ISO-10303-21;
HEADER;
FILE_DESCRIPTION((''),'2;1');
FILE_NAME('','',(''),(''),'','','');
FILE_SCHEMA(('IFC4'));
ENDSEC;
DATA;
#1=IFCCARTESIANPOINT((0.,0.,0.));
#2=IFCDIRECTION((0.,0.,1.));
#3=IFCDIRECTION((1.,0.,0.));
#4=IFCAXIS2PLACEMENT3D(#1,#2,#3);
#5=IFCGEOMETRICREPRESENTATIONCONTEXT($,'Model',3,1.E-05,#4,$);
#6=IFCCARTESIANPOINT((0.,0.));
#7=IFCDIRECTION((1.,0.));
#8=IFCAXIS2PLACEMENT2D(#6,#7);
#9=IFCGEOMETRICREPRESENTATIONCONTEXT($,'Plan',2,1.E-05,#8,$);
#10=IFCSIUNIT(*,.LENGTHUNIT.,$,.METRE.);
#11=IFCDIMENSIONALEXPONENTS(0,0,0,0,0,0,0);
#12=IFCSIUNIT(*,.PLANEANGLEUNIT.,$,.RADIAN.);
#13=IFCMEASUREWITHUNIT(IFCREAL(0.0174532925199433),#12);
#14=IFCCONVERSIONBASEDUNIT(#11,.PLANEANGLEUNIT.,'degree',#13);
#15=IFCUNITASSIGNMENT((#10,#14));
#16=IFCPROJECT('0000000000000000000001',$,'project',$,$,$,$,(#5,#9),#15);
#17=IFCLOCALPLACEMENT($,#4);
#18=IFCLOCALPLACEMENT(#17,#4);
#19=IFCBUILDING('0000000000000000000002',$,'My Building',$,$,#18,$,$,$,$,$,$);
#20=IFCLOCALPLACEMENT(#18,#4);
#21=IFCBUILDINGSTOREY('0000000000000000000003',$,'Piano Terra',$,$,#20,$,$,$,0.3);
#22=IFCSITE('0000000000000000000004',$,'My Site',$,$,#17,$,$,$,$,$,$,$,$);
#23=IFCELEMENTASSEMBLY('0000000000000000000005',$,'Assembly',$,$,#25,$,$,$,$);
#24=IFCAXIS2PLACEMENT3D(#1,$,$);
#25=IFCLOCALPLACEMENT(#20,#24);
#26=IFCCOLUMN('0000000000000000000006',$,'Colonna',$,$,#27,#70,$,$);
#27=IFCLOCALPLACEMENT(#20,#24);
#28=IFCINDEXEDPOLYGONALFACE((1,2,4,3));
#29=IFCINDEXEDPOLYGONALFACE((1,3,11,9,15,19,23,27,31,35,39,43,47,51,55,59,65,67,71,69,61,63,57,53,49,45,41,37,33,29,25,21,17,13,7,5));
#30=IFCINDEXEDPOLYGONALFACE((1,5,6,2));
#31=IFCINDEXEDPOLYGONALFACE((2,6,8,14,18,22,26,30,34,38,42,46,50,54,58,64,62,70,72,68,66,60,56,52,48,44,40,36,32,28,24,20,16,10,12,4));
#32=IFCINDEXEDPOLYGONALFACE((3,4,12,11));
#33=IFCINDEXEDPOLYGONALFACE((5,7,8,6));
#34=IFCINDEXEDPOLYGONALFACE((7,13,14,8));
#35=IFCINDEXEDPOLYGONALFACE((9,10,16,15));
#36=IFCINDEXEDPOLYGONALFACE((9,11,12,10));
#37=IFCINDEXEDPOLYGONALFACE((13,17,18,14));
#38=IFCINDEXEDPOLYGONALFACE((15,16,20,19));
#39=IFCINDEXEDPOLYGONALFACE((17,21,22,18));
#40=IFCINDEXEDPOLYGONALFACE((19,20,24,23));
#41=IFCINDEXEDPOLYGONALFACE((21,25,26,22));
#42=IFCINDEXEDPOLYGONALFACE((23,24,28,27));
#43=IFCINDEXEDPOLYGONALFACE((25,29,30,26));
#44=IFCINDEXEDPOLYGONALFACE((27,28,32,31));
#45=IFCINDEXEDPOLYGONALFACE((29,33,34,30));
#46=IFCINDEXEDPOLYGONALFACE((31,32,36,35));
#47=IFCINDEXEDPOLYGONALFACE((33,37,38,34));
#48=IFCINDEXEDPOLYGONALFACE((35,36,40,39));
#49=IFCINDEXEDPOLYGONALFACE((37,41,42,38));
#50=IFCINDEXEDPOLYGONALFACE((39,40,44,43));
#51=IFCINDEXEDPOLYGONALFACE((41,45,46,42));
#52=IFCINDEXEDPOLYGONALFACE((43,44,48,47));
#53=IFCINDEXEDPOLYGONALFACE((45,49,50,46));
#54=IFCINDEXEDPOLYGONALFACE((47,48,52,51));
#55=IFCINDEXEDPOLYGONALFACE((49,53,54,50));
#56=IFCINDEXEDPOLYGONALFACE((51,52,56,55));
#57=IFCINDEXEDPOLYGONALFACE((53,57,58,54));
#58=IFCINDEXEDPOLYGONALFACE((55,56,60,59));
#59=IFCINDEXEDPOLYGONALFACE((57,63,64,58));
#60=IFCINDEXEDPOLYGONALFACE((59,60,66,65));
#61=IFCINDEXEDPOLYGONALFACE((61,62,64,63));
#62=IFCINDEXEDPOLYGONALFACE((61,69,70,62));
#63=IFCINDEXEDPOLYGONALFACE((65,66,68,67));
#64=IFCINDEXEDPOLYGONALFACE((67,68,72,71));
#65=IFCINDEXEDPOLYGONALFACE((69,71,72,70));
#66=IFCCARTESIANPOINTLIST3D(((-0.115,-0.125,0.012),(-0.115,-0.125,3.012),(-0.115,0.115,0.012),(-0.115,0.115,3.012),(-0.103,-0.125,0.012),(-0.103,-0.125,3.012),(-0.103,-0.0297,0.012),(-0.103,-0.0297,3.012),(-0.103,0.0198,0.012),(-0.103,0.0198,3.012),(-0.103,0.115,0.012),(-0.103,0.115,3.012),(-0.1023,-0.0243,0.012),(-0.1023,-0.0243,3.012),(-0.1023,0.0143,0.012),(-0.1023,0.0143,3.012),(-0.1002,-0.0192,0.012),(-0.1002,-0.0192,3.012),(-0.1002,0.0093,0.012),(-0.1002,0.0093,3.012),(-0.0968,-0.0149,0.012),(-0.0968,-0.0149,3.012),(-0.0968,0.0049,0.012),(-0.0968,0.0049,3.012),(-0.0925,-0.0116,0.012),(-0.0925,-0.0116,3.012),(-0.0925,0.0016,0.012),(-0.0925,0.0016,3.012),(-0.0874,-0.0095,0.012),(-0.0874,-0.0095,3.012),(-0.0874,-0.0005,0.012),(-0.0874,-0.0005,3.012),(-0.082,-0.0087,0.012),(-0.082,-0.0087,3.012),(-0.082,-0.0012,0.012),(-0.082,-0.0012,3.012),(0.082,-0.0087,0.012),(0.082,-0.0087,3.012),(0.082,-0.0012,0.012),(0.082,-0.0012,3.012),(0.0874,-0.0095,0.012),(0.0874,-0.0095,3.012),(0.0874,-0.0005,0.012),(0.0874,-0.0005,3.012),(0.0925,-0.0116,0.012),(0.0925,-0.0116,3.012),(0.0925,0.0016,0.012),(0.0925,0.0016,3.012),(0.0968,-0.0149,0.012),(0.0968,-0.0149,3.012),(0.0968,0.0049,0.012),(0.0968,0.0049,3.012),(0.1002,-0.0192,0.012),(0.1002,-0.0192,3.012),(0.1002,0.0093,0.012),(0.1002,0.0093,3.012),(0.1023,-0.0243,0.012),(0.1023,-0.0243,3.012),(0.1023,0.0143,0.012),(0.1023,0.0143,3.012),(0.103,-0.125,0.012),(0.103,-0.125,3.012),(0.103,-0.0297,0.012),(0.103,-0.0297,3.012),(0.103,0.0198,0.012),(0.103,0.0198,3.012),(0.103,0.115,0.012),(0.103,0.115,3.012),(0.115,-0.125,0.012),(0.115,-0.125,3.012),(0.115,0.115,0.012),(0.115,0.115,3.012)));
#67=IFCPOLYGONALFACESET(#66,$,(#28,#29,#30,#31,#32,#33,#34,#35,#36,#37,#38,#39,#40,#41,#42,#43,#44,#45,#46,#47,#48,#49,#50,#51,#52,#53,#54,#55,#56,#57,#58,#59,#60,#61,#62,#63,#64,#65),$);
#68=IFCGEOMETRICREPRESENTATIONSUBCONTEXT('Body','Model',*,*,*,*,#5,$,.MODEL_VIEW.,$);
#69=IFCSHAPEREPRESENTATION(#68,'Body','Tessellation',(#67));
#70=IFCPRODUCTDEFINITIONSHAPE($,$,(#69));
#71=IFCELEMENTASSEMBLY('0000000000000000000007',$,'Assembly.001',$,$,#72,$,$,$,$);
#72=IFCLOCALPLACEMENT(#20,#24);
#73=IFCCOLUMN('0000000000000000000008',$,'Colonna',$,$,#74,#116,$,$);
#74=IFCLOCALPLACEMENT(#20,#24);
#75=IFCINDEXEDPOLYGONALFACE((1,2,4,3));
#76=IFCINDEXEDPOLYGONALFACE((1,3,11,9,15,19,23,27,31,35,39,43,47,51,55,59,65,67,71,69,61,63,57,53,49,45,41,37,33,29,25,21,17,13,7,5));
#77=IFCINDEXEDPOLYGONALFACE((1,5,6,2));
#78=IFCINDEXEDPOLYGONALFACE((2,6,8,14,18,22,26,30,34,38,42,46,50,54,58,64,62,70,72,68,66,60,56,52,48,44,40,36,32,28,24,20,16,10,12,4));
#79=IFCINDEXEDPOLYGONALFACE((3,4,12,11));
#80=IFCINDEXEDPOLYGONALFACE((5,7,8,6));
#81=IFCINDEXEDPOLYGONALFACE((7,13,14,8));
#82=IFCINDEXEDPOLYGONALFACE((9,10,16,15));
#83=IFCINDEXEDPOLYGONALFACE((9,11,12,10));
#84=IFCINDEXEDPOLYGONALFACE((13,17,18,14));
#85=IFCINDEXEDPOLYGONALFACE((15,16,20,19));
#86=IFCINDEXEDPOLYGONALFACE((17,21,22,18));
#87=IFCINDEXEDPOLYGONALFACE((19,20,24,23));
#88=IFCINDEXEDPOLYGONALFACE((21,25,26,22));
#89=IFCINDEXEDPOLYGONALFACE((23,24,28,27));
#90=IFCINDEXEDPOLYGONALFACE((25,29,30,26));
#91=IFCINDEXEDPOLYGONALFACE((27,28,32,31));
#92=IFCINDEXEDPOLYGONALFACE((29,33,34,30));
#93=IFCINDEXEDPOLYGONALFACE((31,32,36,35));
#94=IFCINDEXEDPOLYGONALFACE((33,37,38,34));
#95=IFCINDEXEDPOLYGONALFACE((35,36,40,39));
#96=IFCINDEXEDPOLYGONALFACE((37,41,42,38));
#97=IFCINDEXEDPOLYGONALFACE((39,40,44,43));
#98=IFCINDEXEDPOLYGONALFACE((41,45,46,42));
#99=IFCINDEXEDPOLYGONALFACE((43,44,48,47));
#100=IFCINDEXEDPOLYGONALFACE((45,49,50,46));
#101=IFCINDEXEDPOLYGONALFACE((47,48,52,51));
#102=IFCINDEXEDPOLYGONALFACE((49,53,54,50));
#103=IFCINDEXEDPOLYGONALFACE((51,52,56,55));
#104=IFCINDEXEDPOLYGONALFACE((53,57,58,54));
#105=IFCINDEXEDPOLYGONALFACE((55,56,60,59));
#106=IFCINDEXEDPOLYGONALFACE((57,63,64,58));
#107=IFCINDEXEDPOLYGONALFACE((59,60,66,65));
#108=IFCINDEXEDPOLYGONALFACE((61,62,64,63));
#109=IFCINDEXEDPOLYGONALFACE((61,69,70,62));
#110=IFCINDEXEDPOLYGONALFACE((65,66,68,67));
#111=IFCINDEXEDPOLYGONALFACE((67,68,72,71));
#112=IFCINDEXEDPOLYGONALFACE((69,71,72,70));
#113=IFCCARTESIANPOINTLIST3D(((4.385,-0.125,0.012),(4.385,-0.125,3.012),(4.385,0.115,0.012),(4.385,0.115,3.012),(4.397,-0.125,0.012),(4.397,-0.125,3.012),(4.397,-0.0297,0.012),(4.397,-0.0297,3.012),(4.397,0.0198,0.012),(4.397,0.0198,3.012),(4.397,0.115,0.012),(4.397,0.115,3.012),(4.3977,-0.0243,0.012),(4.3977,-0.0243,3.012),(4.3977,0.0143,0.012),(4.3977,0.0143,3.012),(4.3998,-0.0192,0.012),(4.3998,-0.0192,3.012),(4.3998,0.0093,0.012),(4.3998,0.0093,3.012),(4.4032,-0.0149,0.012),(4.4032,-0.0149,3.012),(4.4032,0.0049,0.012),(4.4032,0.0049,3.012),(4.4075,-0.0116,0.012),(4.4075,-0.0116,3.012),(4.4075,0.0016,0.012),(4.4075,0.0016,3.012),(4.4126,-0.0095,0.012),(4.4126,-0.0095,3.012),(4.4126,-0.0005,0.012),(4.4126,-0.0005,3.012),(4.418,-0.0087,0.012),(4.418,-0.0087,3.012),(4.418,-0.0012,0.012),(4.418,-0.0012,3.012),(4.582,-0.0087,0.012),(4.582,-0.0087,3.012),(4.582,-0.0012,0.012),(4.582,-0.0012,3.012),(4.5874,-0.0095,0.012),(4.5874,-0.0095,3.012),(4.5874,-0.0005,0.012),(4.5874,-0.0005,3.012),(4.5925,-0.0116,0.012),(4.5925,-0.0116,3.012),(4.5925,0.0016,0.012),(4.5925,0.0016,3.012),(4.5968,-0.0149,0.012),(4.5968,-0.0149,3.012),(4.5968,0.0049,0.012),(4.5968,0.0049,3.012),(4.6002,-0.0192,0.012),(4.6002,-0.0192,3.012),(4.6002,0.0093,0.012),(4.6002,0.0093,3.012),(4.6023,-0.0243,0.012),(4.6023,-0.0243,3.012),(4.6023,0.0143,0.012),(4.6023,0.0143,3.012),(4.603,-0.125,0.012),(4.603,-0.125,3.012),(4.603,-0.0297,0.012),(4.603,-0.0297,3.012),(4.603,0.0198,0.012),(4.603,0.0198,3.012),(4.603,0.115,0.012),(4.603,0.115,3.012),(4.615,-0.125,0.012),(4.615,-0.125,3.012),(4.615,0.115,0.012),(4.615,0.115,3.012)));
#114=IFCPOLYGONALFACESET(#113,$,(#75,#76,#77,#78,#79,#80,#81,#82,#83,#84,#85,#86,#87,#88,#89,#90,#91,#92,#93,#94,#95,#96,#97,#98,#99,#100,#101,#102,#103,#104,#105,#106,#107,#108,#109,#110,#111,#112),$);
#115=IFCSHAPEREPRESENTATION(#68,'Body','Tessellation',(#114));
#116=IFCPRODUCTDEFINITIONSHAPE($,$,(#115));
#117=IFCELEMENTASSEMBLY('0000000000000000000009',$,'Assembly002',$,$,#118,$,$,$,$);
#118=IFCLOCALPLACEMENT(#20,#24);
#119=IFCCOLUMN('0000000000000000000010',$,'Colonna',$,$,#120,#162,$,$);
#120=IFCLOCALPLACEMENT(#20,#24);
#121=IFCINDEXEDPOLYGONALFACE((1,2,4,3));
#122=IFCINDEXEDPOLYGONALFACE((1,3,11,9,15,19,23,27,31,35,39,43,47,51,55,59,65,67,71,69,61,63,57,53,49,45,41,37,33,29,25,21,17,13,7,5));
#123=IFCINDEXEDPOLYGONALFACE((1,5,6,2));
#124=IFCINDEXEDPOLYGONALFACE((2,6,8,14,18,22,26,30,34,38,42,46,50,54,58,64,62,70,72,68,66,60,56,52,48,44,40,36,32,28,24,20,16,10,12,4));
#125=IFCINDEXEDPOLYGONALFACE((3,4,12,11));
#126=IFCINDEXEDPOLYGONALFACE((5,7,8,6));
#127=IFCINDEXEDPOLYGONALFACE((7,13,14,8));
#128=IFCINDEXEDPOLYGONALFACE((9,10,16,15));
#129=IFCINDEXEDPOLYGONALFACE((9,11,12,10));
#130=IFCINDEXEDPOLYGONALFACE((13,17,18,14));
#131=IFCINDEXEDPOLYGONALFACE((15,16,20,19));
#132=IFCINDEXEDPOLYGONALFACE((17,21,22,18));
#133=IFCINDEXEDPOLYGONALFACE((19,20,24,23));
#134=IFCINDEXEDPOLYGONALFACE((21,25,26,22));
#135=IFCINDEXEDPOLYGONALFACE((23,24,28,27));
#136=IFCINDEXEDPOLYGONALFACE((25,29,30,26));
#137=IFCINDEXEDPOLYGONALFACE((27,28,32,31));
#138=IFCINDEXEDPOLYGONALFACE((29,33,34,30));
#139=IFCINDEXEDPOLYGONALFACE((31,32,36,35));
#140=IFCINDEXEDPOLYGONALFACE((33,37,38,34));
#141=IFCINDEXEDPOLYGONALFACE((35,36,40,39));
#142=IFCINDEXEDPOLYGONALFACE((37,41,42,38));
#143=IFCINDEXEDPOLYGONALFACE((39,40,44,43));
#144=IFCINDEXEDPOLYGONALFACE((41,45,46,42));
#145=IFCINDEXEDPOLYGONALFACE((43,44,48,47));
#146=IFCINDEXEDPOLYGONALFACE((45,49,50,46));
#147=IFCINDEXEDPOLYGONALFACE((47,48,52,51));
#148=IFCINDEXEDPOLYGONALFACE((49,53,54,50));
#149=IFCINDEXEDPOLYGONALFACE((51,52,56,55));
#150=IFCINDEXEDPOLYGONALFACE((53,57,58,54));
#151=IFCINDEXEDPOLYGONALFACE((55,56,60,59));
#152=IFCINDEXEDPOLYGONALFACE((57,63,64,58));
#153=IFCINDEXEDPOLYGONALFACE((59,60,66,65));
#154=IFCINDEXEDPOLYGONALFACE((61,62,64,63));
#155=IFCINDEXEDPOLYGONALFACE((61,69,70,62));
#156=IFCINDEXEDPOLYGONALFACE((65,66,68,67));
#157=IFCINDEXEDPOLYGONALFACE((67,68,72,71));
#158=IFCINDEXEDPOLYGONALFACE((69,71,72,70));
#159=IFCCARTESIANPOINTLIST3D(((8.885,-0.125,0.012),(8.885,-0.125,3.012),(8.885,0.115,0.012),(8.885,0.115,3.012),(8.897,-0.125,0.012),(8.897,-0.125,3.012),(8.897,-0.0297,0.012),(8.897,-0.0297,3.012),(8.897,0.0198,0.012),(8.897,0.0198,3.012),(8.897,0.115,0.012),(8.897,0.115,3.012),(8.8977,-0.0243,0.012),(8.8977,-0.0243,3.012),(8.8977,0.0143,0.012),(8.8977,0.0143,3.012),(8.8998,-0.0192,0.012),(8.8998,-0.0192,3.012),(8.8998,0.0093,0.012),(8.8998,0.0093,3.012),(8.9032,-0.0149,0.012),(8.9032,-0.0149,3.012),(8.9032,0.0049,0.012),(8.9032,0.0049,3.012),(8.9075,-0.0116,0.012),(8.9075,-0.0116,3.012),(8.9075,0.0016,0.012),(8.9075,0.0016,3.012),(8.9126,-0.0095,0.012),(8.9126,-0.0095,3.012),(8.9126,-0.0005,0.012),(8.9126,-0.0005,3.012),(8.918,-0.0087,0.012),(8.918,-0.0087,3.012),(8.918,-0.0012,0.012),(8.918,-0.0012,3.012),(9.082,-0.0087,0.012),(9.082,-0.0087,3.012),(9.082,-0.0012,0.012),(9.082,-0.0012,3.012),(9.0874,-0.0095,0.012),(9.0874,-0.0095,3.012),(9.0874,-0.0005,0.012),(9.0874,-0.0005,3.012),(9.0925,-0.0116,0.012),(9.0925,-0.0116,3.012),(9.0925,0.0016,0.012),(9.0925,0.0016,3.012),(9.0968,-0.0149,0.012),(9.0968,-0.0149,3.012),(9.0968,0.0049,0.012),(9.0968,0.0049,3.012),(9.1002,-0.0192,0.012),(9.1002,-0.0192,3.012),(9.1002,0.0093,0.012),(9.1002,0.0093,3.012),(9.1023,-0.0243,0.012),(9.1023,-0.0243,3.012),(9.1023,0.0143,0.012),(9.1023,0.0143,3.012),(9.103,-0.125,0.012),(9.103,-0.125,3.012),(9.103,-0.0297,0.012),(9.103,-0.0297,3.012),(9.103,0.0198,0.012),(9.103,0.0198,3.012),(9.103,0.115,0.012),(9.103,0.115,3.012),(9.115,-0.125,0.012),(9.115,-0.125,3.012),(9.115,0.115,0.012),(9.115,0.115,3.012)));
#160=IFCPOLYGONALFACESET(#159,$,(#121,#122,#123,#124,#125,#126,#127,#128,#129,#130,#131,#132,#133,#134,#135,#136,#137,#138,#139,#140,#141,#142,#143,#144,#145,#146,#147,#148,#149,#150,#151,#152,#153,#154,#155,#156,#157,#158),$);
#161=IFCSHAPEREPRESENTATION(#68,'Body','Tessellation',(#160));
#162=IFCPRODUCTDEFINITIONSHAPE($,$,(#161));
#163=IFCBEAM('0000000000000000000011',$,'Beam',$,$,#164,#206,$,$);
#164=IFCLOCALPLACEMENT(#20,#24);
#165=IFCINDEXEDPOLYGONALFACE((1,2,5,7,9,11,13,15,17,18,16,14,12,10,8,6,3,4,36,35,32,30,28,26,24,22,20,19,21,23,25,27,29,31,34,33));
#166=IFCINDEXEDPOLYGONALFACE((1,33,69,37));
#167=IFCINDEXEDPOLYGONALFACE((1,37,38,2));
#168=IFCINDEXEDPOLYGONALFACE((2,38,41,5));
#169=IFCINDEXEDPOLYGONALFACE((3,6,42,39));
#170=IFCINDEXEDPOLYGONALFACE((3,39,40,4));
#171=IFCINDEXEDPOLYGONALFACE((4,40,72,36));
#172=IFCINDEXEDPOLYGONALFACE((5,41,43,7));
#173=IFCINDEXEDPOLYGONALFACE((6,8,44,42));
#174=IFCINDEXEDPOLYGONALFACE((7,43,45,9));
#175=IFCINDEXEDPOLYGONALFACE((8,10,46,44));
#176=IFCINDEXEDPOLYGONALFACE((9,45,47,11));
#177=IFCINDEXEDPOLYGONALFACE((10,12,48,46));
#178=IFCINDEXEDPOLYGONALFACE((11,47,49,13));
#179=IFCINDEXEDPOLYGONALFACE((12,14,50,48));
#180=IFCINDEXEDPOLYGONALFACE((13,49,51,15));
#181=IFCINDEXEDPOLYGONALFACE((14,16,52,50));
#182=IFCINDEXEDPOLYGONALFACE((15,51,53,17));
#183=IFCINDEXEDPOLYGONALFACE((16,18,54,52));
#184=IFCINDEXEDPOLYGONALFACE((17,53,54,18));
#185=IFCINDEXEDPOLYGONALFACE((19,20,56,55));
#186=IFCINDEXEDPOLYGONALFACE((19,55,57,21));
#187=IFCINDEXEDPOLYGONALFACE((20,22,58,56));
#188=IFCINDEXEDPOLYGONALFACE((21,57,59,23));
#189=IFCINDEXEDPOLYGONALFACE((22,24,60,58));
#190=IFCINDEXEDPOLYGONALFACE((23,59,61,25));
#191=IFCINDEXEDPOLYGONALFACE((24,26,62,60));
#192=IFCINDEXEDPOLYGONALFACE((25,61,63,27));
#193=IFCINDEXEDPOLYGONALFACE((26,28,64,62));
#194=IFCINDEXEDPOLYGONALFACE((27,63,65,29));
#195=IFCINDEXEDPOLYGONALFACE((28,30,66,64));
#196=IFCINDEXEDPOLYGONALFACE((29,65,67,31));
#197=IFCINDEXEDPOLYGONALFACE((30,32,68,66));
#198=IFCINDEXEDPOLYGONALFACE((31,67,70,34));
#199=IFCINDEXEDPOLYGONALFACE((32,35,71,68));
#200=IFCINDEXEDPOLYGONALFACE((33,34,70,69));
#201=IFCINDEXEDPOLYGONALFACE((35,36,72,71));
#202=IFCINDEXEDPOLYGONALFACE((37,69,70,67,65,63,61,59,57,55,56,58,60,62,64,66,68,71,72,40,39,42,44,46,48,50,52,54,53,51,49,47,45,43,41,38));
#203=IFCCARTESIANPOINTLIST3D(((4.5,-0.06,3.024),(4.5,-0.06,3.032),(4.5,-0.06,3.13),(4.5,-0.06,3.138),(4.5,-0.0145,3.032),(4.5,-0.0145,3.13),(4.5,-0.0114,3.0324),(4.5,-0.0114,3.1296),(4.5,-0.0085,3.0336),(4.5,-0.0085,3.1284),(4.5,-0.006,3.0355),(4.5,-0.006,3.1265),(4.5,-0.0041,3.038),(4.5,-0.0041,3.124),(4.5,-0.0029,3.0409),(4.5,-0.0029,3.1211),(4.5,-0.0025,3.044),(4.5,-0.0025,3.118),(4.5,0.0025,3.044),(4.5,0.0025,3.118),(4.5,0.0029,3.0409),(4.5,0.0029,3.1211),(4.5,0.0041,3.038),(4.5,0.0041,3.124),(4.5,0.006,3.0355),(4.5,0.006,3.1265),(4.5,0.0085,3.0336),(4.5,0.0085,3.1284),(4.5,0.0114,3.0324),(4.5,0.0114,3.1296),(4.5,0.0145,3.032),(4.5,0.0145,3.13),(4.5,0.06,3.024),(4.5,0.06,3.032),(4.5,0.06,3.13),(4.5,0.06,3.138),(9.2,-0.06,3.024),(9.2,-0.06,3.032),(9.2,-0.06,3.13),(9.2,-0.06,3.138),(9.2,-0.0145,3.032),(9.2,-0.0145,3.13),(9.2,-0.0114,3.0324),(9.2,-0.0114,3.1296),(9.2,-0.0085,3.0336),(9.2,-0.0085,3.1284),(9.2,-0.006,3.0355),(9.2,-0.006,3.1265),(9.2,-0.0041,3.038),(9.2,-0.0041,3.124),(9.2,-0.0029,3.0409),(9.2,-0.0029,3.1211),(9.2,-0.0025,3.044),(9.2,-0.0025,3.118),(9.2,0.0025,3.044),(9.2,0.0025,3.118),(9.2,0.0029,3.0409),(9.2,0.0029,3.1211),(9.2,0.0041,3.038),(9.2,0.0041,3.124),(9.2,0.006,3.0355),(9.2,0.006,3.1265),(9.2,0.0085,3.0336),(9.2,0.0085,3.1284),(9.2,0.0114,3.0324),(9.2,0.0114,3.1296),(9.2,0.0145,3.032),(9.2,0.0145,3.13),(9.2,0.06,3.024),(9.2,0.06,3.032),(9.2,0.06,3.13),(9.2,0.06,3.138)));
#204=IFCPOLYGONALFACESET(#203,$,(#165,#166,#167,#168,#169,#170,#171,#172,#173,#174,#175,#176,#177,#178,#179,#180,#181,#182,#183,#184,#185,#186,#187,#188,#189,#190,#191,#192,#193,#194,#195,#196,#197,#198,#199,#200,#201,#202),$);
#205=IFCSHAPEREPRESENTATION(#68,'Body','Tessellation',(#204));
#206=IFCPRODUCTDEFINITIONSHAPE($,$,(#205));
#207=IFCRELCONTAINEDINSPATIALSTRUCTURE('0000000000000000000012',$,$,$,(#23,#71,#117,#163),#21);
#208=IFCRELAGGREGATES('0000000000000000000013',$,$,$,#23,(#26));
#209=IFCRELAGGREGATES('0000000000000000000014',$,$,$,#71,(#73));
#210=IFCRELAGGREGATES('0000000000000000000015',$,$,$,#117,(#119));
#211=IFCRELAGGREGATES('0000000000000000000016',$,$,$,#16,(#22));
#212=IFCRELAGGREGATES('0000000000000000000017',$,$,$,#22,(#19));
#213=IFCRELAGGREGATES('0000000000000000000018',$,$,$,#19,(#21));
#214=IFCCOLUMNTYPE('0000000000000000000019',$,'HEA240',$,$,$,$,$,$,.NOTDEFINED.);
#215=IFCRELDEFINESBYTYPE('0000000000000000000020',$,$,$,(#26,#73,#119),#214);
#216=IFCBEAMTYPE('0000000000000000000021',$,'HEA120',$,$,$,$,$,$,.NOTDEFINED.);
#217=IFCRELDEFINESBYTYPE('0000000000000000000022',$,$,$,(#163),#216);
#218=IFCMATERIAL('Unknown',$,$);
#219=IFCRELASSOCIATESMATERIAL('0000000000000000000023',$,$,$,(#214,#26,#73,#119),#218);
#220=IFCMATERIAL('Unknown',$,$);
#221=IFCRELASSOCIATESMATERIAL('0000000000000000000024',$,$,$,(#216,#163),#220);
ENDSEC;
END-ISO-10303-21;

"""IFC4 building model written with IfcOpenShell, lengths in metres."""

from ifc_helpers import new_model, entity, si_unit, converted_unit, frame, origin_with_axes, origin_2d_with_axis, place, context, subcontext, project, spatial, i_section, extrude, material, material_profile, profile_set, profile_usage, type_object, element, aggregate, save


model = new_model("IFC4")

# Units and contexts
model_context = context("Model", 3, precision=1e-05, world=origin_with_axes())
plan_context = context("Plan", 2, precision=1e-05, world=origin_2d_with_axis())
body_context = subcontext(model_context, "Body", "Model", "MODEL_VIEW")
ifc_project = project(units=[si_unit("LENGTHUNIT", "METRE"), converted_unit("PLANEANGLEUNIT", "degree", entity("IfcReal", 0.0174532925199433), si_unit("PLANEANGLEUNIT", "RADIAN"), dimensions=[0, 0, 0, 0, 0, 0, 0])], contexts=[model_context, plan_context])

# Site, building, storey
site_placement = place(None, origin_with_axes())
site = spatial("IfcSite", under=ifc_project, at=site_placement, Name="My Site")
building_placement = place(site_placement, origin_with_axes())
building = spatial("IfcBuilding", under=site, at=building_placement, Name="My Building")
storey_placement = place(building_placement, origin_with_axes())
storey = spatial("IfcBuildingStorey", under=building, at=storey_placement, Name="Piano Terra", Elevation=0.3)

# Element assemblies, columns
assembly_1_placement = place(storey_placement, origin_with_axes())
assembly_1 = element("IfcElementAssembly", 1, at=assembly_1_placement, inside=storey, Name="Assembly")
ifc_material_1 = material(Name="Unknown")
ifc_material_profile_1 = material_profile(ifc_material_1, i_section(OverallWidth=0.24, OverallDepth=0.23, WebThickness=0.0075, FlangeThickness=0.012, FilletRadius=0.021))
ifc_profile_set_1 = profile_set([ifc_material_profile_1])
ifc_profile_usage_1 = profile_usage(ifc_profile_set_1)
column_type = type_object("IfcColumnType", Name="HEA240", PredefinedType="NOTDEFINED", material=ifc_profile_set_1)
column_1_placement = place(assembly_1_placement, frame((0.0, -0.005, 0.012), z_axis=(0.0, 0.0, 1.0), x_axis=(0.0, 1.0, 0.0)))
column_1 = element("IfcColumn", 2, at=column_1_placement, type_object=column_type, material=ifc_profile_usage_1, Name="Colonna", context=body_context, shape_type="SweptSolid", body=[
    extrude(i_section(OverallWidth=0.24, OverallDepth=0.23, WebThickness=0.0075, FlangeThickness=0.012, FilletRadius=0.021), origin_with_axes(), (0.0, 0.0, 1.0), 3.0),
])
assembly_2_placement = place(storey_placement, frame((4.5, 0.0, 0.0), z_axis=(0.0, 0.0, 1.0), x_axis=(1.0, 0.0, 0.0)))
assembly_2 = element("IfcElementAssembly", 3, at=assembly_2_placement, inside=storey, Name="Assembly.001")
ifc_profile_usage_2 = profile_usage(ifc_profile_set_1)
column_2_placement = place(assembly_2_placement, frame((0.0, -0.005, 0.012), z_axis=(0.0, 0.0, 1.0), x_axis=(0.0, 1.0, 0.0)))
column_2 = element("IfcColumn", 4, at=column_2_placement, type_object=column_type, material=ifc_profile_usage_2, Name="Colonna", context=body_context, shape_type="SweptSolid", body=[
    extrude(i_section(OverallWidth=0.24, OverallDepth=0.23, WebThickness=0.0075, FlangeThickness=0.012, FilletRadius=0.021), origin_with_axes(), (0.0, 0.0, 1.0), 3.0),
])
assembly_3_placement = place(storey_placement, frame((9.0, 0.0, 0.0), z_axis=(0.0, 0.0, 1.0), x_axis=(1.0, 0.0, 0.0)))
assembly_3 = element("IfcElementAssembly", 5, at=assembly_3_placement, inside=storey, Name="Assembly002")
ifc_profile_usage_3 = profile_usage(ifc_profile_set_1)
column_3_placement = place(assembly_3_placement, frame((0.0, -0.005, 0.012), z_axis=(0.0, 0.0, 1.0), x_axis=(0.0, 1.0, 0.0)))
column_3 = element("IfcColumn", 6, at=column_3_placement, type_object=column_type, material=ifc_profile_usage_3, Name="Colonna", context=body_context, shape_type="SweptSolid", body=[
    extrude(i_section(OverallWidth=0.24, OverallDepth=0.23, WebThickness=0.0075, FlangeThickness=0.012, FilletRadius=0.021), origin_with_axes(), (0.0, 0.0, 1.0), 3.0),
])

# Beam
ifc_material_2 = material(Name="Unknown")
ifc_material_profile_2 = material_profile(ifc_material_2, i_section(OverallWidth=0.12, OverallDepth=0.114, WebThickness=0.005, FlangeThickness=0.008, FilletRadius=0.012))
ifc_profile_set_2 = profile_set([ifc_material_profile_2])
ifc_profile_usage_4 = profile_usage(ifc_profile_set_2, cardinal=2)
beam_type = type_object("IfcBeamType", Name="HEA120", PredefinedType="NOTDEFINED", material=ifc_profile_set_2)
beam_placement = place(storey_placement, frame((4.5, 0.0, 3.024), z_axis=(1.0, 0.0, 0.0), x_axis=(0.0, 1.0, 0.0)))
element("IfcBeam", 7, at=beam_placement, inside=storey, type_object=beam_type, material=ifc_profile_usage_4, Name="Beam", context=body_context, shape_type="SweptSolid", body=[
    extrude(i_section(OverallWidth=0.12, OverallDepth=0.114, WebThickness=0.005, FlangeThickness=0.008, FilletRadius=0.012), frame((0.0, 0.057, 0.0), z_axis=(0.0, 0.0, 1.0), x_axis=(1.0, 0.0, 0.0)), (0.0, 0.0, 1.0), 4.7),
])

aggregate(assembly_1, [column_1])
aggregate(assembly_2, [column_2])
aggregate(assembly_3, [column_3])

save(model, "model.ifc")
